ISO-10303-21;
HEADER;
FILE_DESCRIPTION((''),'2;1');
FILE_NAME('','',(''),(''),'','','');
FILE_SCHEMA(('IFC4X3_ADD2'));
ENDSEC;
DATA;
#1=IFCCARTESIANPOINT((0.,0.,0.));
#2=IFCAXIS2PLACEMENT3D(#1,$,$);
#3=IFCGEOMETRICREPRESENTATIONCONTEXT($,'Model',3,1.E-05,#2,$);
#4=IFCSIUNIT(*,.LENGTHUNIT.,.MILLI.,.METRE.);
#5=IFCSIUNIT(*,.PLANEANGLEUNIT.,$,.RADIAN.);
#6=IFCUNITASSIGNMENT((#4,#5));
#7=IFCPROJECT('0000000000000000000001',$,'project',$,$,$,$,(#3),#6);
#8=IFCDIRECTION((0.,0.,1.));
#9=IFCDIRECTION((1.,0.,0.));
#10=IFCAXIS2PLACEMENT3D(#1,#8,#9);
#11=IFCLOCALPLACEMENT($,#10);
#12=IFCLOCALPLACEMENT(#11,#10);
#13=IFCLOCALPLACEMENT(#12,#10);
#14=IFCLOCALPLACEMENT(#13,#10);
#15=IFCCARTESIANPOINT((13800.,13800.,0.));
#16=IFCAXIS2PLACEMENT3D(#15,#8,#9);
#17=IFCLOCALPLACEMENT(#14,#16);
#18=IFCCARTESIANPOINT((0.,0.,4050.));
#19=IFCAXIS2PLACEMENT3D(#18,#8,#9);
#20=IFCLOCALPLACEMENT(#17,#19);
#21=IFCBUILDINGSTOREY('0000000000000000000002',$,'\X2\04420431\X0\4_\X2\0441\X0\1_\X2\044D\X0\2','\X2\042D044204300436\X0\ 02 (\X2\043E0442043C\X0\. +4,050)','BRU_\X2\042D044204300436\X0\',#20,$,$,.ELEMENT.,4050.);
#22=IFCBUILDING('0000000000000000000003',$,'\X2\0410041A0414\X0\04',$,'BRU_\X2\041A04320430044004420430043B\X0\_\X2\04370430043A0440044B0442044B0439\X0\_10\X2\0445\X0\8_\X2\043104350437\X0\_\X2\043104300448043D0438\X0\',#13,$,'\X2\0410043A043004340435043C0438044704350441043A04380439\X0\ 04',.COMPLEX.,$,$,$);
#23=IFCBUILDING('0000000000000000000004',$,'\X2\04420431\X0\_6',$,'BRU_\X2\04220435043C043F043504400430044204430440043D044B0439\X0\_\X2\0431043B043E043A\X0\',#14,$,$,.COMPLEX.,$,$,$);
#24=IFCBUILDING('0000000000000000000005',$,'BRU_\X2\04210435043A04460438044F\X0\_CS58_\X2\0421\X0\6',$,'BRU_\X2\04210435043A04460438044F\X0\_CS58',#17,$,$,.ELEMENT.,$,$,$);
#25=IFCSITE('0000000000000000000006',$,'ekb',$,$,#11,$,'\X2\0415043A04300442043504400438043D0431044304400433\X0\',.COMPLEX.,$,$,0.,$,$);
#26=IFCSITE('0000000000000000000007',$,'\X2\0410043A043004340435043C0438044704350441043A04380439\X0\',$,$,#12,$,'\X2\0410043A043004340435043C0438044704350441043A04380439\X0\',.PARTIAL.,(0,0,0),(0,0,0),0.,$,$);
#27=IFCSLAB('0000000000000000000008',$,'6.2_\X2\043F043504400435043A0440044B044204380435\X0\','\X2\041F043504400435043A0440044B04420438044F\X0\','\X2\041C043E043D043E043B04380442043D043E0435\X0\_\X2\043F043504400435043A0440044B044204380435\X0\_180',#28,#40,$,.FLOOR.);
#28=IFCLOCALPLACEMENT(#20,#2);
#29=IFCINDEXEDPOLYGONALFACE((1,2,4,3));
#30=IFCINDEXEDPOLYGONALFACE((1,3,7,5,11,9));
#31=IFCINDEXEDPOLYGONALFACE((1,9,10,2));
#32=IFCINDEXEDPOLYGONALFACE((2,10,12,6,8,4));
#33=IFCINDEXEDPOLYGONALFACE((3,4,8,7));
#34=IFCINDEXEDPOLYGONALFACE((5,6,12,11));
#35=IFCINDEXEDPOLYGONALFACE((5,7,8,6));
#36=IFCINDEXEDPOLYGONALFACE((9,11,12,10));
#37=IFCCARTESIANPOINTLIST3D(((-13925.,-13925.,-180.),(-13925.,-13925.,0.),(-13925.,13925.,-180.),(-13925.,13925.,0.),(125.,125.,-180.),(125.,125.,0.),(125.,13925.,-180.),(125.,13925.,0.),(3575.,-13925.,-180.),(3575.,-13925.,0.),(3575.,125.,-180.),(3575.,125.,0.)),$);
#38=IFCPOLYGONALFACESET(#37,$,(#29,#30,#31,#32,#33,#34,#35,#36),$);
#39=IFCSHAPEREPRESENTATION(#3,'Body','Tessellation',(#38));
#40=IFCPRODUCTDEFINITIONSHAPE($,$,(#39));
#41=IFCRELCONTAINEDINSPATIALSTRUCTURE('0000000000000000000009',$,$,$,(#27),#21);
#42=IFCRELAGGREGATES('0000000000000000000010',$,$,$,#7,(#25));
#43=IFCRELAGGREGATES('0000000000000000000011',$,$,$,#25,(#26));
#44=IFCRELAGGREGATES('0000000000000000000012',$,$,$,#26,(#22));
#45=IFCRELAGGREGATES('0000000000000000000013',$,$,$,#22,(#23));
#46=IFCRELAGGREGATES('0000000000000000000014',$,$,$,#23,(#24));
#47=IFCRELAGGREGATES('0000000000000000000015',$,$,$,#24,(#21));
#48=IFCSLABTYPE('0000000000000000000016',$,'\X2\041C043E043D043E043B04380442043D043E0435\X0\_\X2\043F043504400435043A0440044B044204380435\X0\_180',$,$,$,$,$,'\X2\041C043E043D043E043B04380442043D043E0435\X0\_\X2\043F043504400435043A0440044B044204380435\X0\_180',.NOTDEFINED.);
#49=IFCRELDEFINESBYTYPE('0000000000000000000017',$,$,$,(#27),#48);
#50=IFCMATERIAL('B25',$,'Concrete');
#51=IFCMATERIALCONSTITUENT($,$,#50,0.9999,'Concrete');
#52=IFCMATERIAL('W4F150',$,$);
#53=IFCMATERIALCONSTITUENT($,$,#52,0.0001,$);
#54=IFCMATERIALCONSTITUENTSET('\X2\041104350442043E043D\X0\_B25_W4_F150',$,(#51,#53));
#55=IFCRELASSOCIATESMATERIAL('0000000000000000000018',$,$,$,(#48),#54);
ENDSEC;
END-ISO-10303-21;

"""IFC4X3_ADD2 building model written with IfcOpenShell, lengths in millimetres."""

from ifc_helpers import new_model, si_unit, frame, origin, origin_with_axes, place, context, project, spatial, polyline, outline, extrude, material, constituent, constituent_set, type_object, element, save


model = new_model("IFC4X3_ADD2")

# Units and contexts
model_context = context("Model", 3, precision=1e-05, world=origin())
ifc_project = project(units=[si_unit("LENGTHUNIT", "METRE", prefix="MILLI"), si_unit("PLANEANGLEUNIT", "RADIAN")], contexts=[model_context])

# Sites, buildings, storey
site_1_placement = place(None, origin_with_axes())
site_1 = spatial("IfcSite", under=ifc_project, at=site_1_placement, Name="ekb", LongName="Екатеринбург", CompositionType="COMPLEX", RefElevation=0.0)
site_2_placement = place(site_1_placement, origin_with_axes())
site_2 = spatial("IfcSite", under=site_1, at=site_2_placement, Name="Академический", LongName="Академический", CompositionType="PARTIAL", RefLatitude=(0, 0, 0), RefLongitude=(0, 0, 0), RefElevation=0.0)
building_1_placement = place(site_2_placement, origin_with_axes())
building_1 = spatial("IfcBuilding", under=site_2, at=building_1_placement, Name="АКД04", ObjectType="BRU_Квартал_закрытый_10х8_без_башни", LongName="Академический 04", CompositionType="COMPLEX")
building_2_placement = place(building_1_placement, origin_with_axes())
building_2 = spatial("IfcBuilding", under=building_1, at=building_2_placement, Name="тб_6", ObjectType="BRU_Температурный_блок", CompositionType="COMPLEX")
building_3_placement = place(building_2_placement, frame((13800.0, 13800.0, 0.0), z_axis=(0.0, 0.0, 1.0), x_axis=(1.0, 0.0, 0.0)))
building_3 = spatial("IfcBuilding", under=building_2, at=building_3_placement, Name="BRU_Секция_CS58_С6", ObjectType="BRU_Секция_CS58", CompositionType="ELEMENT")
storey_placement = place(building_3_placement, frame((0.0, 0.0, 4050.0), z_axis=(0.0, 0.0, 1.0), x_axis=(1.0, 0.0, 0.0)))
storey = spatial("IfcBuildingStorey", under=building_3, at=storey_placement, Name="тб4_с1_э2", Description="Этаж 02 (отм. +4,050)", ObjectType="BRU_Этаж", CompositionType="ELEMENT", Elevation=4050.0)

# Shared definitions
ifc_material_1 = material(Name="B25", Category="Concrete")
ifc_material_2 = material(Name="W4F150")

# Slab
ifc_constituent_1 = constituent(ifc_material_1, Category="Concrete", fraction=0.9999)
ifc_constituent_2 = constituent(ifc_material_2, fraction=0.0001)
ifc_constituent_set_1 = constituent_set(constituents=[ifc_constituent_1, ifc_constituent_2], Name="Бетон_B25_W4_F150")
slab_type = type_object("IfcSlabType", Name="Монолитное_перекрытие_180", ElementType="Монолитное_перекрытие_180", PredefinedType="NOTDEFINED", material=ifc_constituent_set_1)
slab_placement = place(storey_placement, frame((0.0, 0.0, -180.0), z_axis=(0.0, 0.0, 1.0), x_axis=(1.0, 0.0, 0.0)))
element("IfcSlab", 1, at=slab_placement, inside=storey, type_object=slab_type, Name="6.2_перекрытие", Description="Перекрытия", ObjectType="Монолитное_перекрытие_180", PredefinedType="FLOOR", context=model_context, shape_type="SweptSolid", body=[
    extrude(outline(polyline([(-13925.0, -13925.0), (3575.0, -13925.0), (3575.0, 125.0), (125.0, 125.0), (125.0, 13925.0), (-13925.0, 13925.0), (-13925.0, -13925.0)])), origin_with_axes(), (0.0, 0.0, 1.0), 180.0),
])

save(model, "model.ifc")
